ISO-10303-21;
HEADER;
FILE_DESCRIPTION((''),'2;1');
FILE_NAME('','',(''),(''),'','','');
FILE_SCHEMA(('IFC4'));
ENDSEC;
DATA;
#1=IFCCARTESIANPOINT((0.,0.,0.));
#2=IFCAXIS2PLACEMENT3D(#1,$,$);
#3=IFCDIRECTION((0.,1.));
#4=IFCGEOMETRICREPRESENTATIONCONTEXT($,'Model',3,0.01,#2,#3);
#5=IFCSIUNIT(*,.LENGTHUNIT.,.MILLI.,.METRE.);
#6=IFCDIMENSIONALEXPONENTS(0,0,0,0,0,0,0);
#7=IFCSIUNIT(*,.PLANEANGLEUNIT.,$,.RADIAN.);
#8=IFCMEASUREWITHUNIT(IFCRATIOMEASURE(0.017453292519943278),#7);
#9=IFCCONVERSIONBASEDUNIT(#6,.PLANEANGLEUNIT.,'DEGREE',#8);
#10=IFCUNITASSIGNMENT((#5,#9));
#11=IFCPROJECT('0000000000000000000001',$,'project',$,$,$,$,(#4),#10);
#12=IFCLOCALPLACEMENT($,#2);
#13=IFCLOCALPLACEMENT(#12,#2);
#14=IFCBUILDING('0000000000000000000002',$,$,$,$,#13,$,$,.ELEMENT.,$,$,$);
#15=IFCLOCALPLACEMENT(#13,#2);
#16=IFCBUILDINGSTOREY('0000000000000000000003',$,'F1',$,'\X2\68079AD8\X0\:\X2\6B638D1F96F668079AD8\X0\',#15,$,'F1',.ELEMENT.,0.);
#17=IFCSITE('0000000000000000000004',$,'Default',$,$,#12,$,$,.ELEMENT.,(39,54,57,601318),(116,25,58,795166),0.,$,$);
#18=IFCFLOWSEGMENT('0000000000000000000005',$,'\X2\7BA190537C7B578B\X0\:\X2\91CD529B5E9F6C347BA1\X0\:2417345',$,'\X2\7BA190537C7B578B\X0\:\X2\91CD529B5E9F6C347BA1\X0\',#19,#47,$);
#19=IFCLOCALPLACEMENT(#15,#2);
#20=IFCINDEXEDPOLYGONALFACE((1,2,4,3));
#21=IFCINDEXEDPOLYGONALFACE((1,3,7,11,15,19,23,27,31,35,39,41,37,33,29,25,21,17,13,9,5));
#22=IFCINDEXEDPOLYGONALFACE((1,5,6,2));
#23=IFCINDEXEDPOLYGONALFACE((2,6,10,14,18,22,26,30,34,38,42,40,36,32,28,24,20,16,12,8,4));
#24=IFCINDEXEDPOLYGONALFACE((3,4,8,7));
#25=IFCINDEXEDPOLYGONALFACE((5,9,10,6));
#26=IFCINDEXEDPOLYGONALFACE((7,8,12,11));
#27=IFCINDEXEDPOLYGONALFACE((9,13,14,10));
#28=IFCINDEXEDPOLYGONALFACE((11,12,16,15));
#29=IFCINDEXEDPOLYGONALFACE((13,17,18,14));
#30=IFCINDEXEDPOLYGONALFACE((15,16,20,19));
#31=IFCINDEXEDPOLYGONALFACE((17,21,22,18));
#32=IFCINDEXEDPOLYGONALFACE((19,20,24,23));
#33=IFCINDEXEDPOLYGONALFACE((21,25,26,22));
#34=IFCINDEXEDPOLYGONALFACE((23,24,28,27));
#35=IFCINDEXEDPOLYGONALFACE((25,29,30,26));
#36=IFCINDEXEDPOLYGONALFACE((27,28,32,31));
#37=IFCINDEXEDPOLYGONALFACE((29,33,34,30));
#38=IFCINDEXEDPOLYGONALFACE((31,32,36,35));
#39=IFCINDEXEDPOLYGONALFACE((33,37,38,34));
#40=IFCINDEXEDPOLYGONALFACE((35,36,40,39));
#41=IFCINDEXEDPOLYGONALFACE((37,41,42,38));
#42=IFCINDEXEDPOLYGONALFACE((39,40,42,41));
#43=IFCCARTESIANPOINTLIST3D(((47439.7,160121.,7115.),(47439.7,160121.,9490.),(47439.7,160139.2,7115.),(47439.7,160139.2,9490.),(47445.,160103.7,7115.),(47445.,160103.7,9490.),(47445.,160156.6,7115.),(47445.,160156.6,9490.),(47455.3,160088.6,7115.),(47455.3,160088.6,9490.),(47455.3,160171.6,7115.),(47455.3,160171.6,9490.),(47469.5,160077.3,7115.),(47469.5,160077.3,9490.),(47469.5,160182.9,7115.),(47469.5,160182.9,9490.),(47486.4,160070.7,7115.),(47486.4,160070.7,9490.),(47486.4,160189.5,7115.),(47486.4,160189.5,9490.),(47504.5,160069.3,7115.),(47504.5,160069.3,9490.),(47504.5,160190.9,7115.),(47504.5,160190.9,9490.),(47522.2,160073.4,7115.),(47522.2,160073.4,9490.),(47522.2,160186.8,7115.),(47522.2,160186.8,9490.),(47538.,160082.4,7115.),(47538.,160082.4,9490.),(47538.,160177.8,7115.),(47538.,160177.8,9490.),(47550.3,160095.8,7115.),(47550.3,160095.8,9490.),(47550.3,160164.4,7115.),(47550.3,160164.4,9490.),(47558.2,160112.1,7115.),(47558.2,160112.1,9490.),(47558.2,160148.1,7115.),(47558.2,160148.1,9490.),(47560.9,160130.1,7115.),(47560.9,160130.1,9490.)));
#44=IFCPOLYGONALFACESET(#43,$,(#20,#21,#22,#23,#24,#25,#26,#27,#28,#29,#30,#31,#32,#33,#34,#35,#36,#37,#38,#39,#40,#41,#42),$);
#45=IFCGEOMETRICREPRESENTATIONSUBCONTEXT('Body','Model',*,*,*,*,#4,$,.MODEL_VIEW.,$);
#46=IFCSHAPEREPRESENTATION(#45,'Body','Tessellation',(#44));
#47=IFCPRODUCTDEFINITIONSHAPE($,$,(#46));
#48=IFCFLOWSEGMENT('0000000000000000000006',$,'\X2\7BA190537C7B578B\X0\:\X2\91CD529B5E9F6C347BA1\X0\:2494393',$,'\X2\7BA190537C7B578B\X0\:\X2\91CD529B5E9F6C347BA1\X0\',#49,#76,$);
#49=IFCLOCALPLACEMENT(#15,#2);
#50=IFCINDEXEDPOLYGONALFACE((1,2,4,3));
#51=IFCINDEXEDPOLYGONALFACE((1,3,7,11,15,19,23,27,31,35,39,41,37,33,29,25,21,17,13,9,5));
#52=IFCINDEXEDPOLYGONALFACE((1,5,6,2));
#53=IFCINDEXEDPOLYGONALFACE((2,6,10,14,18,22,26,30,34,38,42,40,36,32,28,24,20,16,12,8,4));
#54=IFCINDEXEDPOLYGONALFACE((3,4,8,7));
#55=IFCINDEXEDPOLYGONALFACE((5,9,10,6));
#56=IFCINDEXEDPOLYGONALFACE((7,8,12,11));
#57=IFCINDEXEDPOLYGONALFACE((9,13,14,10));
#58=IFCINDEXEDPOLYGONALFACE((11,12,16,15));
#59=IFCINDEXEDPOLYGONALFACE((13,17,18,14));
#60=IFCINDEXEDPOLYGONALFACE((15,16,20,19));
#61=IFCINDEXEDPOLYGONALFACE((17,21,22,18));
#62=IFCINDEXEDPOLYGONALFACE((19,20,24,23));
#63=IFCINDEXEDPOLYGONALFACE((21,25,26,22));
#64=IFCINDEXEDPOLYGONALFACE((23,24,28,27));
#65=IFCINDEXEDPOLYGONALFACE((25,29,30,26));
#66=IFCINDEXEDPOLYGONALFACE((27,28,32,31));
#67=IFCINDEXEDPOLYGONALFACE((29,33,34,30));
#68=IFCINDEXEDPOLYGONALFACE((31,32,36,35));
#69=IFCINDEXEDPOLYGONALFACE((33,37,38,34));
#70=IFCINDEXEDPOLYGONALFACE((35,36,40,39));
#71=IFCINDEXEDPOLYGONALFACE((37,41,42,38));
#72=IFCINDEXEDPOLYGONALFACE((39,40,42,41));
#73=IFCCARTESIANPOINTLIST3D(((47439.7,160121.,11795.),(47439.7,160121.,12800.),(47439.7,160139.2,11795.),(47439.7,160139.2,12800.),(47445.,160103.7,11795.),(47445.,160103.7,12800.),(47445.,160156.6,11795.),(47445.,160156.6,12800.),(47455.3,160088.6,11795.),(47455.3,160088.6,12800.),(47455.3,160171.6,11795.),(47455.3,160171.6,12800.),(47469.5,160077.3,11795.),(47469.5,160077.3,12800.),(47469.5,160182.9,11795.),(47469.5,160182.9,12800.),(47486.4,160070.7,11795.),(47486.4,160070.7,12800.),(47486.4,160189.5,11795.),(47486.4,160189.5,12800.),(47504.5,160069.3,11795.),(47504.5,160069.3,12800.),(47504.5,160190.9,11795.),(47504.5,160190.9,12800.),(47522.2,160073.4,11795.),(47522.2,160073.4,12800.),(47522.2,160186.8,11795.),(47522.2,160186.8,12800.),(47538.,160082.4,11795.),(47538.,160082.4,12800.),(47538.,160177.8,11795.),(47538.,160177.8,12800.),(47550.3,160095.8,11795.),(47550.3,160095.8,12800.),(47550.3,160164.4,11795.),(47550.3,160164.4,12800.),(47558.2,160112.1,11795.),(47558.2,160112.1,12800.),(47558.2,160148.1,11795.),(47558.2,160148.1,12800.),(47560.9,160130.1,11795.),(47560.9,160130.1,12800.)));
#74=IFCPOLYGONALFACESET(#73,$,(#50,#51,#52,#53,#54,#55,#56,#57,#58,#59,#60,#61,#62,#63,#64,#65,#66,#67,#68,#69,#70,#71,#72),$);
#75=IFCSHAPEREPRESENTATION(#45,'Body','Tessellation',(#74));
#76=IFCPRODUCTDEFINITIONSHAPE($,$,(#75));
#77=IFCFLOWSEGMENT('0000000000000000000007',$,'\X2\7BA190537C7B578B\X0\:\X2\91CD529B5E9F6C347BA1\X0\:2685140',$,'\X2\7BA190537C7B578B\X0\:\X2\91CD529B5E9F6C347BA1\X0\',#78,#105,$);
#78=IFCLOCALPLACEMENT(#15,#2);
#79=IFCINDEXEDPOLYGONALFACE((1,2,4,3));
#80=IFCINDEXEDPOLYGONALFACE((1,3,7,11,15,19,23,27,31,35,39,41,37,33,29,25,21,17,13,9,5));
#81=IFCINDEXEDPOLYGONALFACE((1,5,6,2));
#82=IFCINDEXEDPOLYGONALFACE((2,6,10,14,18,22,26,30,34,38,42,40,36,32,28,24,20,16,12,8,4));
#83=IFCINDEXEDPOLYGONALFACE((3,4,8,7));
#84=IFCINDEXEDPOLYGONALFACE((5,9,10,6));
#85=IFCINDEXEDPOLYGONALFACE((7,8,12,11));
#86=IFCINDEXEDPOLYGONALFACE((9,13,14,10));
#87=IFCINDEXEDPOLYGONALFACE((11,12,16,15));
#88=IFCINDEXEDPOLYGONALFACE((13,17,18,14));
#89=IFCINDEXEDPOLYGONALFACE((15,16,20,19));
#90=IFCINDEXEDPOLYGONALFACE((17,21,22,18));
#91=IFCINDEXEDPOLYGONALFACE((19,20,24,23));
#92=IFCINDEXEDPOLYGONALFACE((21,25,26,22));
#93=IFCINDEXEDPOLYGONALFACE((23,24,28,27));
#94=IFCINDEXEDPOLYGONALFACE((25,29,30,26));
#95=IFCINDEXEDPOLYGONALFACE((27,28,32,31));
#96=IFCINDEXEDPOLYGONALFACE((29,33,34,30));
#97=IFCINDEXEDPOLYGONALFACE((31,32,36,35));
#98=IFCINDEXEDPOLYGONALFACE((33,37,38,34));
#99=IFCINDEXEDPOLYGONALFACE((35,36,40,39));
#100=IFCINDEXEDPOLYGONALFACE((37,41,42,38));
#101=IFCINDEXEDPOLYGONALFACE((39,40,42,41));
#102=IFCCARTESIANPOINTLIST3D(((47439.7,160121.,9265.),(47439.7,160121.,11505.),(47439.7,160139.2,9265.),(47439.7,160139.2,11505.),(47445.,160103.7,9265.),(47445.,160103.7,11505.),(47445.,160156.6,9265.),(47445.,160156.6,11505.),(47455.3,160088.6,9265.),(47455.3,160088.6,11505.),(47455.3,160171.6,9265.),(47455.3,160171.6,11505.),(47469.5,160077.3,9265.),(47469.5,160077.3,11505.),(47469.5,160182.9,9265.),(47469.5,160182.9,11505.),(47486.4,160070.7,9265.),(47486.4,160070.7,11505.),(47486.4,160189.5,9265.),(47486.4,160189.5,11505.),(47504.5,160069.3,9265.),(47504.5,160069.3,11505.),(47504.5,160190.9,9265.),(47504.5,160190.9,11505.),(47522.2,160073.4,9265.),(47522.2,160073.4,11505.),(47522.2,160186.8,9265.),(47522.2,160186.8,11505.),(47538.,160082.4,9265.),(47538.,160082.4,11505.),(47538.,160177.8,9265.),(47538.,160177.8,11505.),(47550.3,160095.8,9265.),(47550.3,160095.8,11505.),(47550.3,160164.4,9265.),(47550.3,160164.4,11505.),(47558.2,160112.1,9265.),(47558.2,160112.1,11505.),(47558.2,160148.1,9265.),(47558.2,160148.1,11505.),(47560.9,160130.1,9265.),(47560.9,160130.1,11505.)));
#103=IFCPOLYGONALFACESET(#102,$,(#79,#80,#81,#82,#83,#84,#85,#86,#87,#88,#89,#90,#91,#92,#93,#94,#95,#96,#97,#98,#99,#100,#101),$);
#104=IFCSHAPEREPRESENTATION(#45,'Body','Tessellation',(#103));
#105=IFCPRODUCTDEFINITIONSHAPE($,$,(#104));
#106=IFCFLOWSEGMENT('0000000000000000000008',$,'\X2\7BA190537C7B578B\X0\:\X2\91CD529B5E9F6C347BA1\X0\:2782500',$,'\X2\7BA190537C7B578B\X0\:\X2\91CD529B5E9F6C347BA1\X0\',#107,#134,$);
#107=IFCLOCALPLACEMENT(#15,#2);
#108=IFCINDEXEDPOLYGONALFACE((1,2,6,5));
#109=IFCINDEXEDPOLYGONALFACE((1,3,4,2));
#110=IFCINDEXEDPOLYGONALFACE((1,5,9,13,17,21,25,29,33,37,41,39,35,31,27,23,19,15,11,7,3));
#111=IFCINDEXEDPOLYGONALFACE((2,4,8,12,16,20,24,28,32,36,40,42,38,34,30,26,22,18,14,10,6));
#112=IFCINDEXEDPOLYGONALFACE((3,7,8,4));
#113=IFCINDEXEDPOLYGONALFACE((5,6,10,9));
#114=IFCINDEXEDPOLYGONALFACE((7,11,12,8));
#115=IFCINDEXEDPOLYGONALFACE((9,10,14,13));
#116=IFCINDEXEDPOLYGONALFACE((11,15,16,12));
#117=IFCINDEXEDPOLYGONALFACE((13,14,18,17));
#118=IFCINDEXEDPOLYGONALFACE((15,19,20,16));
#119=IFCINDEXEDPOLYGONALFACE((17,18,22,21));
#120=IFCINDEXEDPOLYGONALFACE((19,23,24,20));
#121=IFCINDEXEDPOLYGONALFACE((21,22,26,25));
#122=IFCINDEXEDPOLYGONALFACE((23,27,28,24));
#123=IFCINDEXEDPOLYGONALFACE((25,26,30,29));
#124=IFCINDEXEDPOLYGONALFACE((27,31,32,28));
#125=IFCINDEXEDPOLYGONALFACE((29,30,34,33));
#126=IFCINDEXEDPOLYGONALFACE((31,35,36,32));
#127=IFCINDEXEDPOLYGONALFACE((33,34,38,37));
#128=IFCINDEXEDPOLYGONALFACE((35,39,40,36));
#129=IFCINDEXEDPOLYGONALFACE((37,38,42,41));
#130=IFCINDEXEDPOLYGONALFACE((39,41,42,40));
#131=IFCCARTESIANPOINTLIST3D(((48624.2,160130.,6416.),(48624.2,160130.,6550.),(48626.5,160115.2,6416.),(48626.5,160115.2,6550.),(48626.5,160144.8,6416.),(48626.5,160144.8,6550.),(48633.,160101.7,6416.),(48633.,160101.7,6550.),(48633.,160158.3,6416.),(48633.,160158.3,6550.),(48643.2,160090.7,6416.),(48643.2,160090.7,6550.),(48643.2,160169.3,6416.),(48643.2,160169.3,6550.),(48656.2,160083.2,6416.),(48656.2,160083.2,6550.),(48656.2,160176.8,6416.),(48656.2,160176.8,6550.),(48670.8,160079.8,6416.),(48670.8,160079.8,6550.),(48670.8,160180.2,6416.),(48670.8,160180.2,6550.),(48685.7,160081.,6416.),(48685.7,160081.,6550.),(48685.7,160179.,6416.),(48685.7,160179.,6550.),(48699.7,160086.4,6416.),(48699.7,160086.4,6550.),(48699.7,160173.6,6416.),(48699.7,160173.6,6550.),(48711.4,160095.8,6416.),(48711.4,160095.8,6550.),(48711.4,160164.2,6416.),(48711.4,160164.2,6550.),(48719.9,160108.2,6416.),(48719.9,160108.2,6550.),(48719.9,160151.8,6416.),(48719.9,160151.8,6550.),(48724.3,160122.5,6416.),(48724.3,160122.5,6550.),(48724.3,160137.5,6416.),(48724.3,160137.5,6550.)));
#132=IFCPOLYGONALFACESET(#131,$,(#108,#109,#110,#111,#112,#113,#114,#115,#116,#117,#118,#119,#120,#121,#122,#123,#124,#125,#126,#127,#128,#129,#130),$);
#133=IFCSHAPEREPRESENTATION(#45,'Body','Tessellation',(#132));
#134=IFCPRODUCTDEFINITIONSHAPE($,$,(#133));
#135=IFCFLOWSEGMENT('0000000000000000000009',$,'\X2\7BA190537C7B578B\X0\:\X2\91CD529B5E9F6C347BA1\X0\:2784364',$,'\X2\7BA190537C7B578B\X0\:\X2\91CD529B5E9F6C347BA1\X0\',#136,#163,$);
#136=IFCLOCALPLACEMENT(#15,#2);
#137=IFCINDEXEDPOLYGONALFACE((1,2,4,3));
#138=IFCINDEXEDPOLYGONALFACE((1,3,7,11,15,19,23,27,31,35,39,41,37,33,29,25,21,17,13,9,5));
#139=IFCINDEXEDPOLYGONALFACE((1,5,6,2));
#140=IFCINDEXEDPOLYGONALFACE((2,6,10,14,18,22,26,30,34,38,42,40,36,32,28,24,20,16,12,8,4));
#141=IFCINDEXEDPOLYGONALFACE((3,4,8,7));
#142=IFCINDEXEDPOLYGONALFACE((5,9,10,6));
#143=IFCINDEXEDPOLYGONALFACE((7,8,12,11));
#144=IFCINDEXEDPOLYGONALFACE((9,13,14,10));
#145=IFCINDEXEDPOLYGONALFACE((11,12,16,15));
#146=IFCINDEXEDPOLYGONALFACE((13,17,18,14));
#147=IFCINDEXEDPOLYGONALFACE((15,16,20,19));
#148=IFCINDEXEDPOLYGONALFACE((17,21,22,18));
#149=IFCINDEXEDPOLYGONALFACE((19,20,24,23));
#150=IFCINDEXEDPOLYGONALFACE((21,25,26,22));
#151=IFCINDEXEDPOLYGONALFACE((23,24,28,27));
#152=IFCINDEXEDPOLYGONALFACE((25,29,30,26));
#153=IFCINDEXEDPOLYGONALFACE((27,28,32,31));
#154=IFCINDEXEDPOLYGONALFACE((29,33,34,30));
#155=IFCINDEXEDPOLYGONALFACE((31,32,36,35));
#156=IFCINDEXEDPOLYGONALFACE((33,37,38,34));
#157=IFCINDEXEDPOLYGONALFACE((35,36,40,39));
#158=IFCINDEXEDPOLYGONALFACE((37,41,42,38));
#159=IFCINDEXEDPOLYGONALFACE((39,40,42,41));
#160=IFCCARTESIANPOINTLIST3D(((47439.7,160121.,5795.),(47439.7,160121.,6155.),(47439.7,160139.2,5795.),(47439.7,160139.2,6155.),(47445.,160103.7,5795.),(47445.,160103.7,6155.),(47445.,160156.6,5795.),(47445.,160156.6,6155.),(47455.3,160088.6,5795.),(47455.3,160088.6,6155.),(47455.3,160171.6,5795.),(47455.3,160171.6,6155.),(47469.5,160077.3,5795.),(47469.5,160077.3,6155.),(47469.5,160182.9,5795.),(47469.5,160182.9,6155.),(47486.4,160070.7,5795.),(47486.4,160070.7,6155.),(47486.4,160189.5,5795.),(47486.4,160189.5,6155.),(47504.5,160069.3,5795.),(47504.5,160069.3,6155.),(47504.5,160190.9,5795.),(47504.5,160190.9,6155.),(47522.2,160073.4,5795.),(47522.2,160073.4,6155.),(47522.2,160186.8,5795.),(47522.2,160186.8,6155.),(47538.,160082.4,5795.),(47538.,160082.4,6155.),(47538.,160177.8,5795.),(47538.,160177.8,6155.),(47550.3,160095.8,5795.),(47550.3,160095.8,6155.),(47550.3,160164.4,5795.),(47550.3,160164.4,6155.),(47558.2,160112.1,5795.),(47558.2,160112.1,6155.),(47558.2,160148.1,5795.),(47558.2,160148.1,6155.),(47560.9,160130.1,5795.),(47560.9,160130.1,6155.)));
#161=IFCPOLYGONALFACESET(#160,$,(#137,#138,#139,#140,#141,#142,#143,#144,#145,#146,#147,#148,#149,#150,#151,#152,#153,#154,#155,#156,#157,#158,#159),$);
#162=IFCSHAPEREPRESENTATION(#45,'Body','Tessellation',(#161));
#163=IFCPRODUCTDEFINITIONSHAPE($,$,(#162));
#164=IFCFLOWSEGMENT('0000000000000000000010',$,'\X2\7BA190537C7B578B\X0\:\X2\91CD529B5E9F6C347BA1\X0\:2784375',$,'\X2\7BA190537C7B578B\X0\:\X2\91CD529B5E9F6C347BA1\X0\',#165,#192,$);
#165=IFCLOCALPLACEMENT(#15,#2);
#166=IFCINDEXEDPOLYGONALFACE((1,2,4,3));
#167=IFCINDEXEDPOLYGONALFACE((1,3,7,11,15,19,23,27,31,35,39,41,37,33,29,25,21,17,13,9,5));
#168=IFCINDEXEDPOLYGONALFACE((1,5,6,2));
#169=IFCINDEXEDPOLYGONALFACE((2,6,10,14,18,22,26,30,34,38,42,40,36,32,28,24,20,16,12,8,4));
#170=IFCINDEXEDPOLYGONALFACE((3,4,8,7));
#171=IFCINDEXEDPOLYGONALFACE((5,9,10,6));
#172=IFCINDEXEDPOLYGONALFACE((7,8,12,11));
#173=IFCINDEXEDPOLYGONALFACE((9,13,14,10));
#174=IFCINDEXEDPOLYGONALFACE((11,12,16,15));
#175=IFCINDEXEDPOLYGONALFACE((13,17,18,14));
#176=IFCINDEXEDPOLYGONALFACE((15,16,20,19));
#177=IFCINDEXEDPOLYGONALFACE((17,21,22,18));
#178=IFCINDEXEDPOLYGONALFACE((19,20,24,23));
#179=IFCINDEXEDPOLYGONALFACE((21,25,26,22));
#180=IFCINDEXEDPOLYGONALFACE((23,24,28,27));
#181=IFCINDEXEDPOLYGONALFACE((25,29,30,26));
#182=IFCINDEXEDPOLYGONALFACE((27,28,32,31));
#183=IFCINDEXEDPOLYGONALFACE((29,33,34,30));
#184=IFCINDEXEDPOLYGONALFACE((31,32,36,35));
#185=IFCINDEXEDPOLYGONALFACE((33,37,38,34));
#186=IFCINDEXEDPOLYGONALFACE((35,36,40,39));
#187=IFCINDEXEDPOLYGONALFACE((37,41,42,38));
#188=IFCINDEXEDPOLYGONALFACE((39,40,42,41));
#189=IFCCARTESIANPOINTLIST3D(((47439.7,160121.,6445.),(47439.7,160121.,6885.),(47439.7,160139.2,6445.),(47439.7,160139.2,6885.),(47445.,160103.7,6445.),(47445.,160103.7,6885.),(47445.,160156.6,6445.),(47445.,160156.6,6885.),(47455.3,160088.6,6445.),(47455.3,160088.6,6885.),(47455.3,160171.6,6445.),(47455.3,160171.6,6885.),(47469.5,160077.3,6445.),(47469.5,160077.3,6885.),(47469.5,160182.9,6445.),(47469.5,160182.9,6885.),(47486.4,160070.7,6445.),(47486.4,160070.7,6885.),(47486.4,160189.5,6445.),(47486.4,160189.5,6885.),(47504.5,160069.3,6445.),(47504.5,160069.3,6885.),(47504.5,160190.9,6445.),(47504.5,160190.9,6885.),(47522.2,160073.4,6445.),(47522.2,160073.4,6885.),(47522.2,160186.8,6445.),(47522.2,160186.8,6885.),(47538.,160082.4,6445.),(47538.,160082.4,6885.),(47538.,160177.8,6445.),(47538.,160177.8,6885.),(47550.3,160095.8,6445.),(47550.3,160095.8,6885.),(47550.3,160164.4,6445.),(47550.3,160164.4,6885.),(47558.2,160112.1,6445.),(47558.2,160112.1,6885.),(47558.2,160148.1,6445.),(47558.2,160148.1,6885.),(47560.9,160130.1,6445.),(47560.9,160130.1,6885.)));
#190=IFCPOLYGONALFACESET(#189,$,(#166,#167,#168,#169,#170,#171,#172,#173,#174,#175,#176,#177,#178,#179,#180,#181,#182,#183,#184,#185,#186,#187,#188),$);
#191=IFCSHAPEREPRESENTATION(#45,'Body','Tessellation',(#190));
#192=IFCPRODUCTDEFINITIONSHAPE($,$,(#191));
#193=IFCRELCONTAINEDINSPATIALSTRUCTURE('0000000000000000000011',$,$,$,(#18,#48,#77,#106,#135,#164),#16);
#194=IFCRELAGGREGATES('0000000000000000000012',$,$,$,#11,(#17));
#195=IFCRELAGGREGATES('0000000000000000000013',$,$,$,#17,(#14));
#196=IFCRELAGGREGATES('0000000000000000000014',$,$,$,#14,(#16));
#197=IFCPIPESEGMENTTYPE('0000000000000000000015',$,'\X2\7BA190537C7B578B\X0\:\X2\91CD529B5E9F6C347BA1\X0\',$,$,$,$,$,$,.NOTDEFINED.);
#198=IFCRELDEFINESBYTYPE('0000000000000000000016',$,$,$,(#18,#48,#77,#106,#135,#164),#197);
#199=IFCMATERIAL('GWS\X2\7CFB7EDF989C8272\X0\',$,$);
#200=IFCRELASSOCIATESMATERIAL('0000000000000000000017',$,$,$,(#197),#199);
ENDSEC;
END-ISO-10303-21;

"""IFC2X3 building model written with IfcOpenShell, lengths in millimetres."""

from ifc_helpers import new_model, entity, si_unit, converted_unit, direction, frame, origin, origin_2d_with_axis, place, context, subcontext, project, spatial, circle, extrude, material, type_object, element, save


model = new_model("IFC2X3")

# Units and contexts
model_context = context("Model", 3, precision=0.01, world=origin(), true_north=direction((0.0, 1.0)))
body_context = subcontext(model_context, "Body", "Model", "MODEL_VIEW")
ifc_project = project(units=[si_unit("LENGTHUNIT", "METRE", prefix="MILLI"), converted_unit("PLANEANGLEUNIT", "DEGREE", entity("IfcRatioMeasure", 0.017453292519943278), si_unit("PLANEANGLEUNIT", "RADIAN"), dimensions=[0, 0, 0, 0, 0, 0, 0])], contexts=[model_context])

# Site, building, storey
site_placement = place(None, origin())
site = spatial("IfcSite", under=ifc_project, at=site_placement, Name="Default", CompositionType="ELEMENT", RefLatitude=(39, 54, 57, 601318), RefLongitude=(116, 25, 58, 795166), RefElevation=0.0)
building_placement = place(site_placement, origin())
building = spatial("IfcBuilding", under=site, at=building_placement, CompositionType="ELEMENT")
storey_placement = place(building_placement, origin())
storey = spatial("IfcBuildingStorey", under=building, at=storey_placement, Name="F1", ObjectType="标高:正负零标高", LongName="F1", CompositionType="ELEMENT", Elevation=0.0)

# Flow segments
ifc_material_1 = material(Name="GWS系统颜色")
pipe_segment_type_1 = type_object("IfcPipeSegmentType", Name="管道类型:重力废水管", PredefinedType="NOTDEFINED", material=ifc_material_1)
flow_segment_1_placement = place(storey_placement, origin())
element("IfcFlowSegment", 1, at=flow_segment_1_placement, inside=storey, type_object=pipe_segment_type_1, Name="管道类型:重力废水管:2417345", ObjectType="管道类型:重力废水管", context=body_context, shape_type="SweptSolid", body=[
    extrude(circle(Radius=61.0, at=origin_2d_with_axis()), frame((47500.0, 160130.1, 7115.0)), (0.0, 0.0, 1.0), 2375.0),
])
flow_segment_2_placement = place(storey_placement, origin())
element("IfcFlowSegment", 2, at=flow_segment_2_placement, inside=storey, type_object=pipe_segment_type_1, Name="管道类型:重力废水管:2494393", ObjectType="管道类型:重力废水管", context=body_context, shape_type="SweptSolid", body=[
    extrude(circle(Radius=61.0, at=origin_2d_with_axis()), frame((47500.0, 160130.1, 11795.0)), (0.0, 0.0, 1.0), 1005.0),
])
flow_segment_3_placement = place(storey_placement, origin())
element("IfcFlowSegment", 3, at=flow_segment_3_placement, inside=storey, type_object=pipe_segment_type_1, Name="管道类型:重力废水管:2685140", ObjectType="管道类型:重力废水管", context=body_context, shape_type="SweptSolid", body=[
    extrude(circle(Radius=61.0, at=origin_2d_with_axis()), frame((47500.0, 160130.1, 9265.0)), (0.0, 0.0, 1.0), 2240.0),
])
flow_segment_4_placement = place(storey_placement, origin())
element("IfcFlowSegment", 4, at=flow_segment_4_placement, inside=storey, type_object=pipe_segment_type_1, Name="管道类型:重力废水管:2782500", ObjectType="管道类型:重力废水管", context=body_context, shape_type="SweptSolid", body=[
    extrude(circle(Radius=50.3, at=origin_2d_with_axis()), frame((48674.5, 160130.0, 6416.0), z_axis=(0.0, 0.0, 1.0), x_axis=(-1.0, 0.0, 0.0)), (0.0, 0.0, 1.0), 134.0),
])
flow_segment_5_placement = place(storey_placement, origin())
element("IfcFlowSegment", 5, at=flow_segment_5_placement, inside=storey, type_object=pipe_segment_type_1, Name="管道类型:重力废水管:2784364", ObjectType="管道类型:重力废水管", context=body_context, shape_type="SweptSolid", body=[
    extrude(circle(Radius=61.0, at=origin_2d_with_axis()), frame((47500.0, 160130.1, 5795.0)), (0.0, 0.0, 1.0), 360.0),
])
flow_segment_6_placement = place(storey_placement, origin())
element("IfcFlowSegment", 6, at=flow_segment_6_placement, inside=storey, type_object=pipe_segment_type_1, Name="管道类型:重力废水管:2784375", ObjectType="管道类型:重力废水管", context=body_context, shape_type="SweptSolid", body=[
    extrude(circle(Radius=61.0, at=origin_2d_with_axis()), frame((47500.0, 160130.1, 6445.0)), (0.0, 0.0, 1.0), 440.0),
])

save(model, "model.ifc")
